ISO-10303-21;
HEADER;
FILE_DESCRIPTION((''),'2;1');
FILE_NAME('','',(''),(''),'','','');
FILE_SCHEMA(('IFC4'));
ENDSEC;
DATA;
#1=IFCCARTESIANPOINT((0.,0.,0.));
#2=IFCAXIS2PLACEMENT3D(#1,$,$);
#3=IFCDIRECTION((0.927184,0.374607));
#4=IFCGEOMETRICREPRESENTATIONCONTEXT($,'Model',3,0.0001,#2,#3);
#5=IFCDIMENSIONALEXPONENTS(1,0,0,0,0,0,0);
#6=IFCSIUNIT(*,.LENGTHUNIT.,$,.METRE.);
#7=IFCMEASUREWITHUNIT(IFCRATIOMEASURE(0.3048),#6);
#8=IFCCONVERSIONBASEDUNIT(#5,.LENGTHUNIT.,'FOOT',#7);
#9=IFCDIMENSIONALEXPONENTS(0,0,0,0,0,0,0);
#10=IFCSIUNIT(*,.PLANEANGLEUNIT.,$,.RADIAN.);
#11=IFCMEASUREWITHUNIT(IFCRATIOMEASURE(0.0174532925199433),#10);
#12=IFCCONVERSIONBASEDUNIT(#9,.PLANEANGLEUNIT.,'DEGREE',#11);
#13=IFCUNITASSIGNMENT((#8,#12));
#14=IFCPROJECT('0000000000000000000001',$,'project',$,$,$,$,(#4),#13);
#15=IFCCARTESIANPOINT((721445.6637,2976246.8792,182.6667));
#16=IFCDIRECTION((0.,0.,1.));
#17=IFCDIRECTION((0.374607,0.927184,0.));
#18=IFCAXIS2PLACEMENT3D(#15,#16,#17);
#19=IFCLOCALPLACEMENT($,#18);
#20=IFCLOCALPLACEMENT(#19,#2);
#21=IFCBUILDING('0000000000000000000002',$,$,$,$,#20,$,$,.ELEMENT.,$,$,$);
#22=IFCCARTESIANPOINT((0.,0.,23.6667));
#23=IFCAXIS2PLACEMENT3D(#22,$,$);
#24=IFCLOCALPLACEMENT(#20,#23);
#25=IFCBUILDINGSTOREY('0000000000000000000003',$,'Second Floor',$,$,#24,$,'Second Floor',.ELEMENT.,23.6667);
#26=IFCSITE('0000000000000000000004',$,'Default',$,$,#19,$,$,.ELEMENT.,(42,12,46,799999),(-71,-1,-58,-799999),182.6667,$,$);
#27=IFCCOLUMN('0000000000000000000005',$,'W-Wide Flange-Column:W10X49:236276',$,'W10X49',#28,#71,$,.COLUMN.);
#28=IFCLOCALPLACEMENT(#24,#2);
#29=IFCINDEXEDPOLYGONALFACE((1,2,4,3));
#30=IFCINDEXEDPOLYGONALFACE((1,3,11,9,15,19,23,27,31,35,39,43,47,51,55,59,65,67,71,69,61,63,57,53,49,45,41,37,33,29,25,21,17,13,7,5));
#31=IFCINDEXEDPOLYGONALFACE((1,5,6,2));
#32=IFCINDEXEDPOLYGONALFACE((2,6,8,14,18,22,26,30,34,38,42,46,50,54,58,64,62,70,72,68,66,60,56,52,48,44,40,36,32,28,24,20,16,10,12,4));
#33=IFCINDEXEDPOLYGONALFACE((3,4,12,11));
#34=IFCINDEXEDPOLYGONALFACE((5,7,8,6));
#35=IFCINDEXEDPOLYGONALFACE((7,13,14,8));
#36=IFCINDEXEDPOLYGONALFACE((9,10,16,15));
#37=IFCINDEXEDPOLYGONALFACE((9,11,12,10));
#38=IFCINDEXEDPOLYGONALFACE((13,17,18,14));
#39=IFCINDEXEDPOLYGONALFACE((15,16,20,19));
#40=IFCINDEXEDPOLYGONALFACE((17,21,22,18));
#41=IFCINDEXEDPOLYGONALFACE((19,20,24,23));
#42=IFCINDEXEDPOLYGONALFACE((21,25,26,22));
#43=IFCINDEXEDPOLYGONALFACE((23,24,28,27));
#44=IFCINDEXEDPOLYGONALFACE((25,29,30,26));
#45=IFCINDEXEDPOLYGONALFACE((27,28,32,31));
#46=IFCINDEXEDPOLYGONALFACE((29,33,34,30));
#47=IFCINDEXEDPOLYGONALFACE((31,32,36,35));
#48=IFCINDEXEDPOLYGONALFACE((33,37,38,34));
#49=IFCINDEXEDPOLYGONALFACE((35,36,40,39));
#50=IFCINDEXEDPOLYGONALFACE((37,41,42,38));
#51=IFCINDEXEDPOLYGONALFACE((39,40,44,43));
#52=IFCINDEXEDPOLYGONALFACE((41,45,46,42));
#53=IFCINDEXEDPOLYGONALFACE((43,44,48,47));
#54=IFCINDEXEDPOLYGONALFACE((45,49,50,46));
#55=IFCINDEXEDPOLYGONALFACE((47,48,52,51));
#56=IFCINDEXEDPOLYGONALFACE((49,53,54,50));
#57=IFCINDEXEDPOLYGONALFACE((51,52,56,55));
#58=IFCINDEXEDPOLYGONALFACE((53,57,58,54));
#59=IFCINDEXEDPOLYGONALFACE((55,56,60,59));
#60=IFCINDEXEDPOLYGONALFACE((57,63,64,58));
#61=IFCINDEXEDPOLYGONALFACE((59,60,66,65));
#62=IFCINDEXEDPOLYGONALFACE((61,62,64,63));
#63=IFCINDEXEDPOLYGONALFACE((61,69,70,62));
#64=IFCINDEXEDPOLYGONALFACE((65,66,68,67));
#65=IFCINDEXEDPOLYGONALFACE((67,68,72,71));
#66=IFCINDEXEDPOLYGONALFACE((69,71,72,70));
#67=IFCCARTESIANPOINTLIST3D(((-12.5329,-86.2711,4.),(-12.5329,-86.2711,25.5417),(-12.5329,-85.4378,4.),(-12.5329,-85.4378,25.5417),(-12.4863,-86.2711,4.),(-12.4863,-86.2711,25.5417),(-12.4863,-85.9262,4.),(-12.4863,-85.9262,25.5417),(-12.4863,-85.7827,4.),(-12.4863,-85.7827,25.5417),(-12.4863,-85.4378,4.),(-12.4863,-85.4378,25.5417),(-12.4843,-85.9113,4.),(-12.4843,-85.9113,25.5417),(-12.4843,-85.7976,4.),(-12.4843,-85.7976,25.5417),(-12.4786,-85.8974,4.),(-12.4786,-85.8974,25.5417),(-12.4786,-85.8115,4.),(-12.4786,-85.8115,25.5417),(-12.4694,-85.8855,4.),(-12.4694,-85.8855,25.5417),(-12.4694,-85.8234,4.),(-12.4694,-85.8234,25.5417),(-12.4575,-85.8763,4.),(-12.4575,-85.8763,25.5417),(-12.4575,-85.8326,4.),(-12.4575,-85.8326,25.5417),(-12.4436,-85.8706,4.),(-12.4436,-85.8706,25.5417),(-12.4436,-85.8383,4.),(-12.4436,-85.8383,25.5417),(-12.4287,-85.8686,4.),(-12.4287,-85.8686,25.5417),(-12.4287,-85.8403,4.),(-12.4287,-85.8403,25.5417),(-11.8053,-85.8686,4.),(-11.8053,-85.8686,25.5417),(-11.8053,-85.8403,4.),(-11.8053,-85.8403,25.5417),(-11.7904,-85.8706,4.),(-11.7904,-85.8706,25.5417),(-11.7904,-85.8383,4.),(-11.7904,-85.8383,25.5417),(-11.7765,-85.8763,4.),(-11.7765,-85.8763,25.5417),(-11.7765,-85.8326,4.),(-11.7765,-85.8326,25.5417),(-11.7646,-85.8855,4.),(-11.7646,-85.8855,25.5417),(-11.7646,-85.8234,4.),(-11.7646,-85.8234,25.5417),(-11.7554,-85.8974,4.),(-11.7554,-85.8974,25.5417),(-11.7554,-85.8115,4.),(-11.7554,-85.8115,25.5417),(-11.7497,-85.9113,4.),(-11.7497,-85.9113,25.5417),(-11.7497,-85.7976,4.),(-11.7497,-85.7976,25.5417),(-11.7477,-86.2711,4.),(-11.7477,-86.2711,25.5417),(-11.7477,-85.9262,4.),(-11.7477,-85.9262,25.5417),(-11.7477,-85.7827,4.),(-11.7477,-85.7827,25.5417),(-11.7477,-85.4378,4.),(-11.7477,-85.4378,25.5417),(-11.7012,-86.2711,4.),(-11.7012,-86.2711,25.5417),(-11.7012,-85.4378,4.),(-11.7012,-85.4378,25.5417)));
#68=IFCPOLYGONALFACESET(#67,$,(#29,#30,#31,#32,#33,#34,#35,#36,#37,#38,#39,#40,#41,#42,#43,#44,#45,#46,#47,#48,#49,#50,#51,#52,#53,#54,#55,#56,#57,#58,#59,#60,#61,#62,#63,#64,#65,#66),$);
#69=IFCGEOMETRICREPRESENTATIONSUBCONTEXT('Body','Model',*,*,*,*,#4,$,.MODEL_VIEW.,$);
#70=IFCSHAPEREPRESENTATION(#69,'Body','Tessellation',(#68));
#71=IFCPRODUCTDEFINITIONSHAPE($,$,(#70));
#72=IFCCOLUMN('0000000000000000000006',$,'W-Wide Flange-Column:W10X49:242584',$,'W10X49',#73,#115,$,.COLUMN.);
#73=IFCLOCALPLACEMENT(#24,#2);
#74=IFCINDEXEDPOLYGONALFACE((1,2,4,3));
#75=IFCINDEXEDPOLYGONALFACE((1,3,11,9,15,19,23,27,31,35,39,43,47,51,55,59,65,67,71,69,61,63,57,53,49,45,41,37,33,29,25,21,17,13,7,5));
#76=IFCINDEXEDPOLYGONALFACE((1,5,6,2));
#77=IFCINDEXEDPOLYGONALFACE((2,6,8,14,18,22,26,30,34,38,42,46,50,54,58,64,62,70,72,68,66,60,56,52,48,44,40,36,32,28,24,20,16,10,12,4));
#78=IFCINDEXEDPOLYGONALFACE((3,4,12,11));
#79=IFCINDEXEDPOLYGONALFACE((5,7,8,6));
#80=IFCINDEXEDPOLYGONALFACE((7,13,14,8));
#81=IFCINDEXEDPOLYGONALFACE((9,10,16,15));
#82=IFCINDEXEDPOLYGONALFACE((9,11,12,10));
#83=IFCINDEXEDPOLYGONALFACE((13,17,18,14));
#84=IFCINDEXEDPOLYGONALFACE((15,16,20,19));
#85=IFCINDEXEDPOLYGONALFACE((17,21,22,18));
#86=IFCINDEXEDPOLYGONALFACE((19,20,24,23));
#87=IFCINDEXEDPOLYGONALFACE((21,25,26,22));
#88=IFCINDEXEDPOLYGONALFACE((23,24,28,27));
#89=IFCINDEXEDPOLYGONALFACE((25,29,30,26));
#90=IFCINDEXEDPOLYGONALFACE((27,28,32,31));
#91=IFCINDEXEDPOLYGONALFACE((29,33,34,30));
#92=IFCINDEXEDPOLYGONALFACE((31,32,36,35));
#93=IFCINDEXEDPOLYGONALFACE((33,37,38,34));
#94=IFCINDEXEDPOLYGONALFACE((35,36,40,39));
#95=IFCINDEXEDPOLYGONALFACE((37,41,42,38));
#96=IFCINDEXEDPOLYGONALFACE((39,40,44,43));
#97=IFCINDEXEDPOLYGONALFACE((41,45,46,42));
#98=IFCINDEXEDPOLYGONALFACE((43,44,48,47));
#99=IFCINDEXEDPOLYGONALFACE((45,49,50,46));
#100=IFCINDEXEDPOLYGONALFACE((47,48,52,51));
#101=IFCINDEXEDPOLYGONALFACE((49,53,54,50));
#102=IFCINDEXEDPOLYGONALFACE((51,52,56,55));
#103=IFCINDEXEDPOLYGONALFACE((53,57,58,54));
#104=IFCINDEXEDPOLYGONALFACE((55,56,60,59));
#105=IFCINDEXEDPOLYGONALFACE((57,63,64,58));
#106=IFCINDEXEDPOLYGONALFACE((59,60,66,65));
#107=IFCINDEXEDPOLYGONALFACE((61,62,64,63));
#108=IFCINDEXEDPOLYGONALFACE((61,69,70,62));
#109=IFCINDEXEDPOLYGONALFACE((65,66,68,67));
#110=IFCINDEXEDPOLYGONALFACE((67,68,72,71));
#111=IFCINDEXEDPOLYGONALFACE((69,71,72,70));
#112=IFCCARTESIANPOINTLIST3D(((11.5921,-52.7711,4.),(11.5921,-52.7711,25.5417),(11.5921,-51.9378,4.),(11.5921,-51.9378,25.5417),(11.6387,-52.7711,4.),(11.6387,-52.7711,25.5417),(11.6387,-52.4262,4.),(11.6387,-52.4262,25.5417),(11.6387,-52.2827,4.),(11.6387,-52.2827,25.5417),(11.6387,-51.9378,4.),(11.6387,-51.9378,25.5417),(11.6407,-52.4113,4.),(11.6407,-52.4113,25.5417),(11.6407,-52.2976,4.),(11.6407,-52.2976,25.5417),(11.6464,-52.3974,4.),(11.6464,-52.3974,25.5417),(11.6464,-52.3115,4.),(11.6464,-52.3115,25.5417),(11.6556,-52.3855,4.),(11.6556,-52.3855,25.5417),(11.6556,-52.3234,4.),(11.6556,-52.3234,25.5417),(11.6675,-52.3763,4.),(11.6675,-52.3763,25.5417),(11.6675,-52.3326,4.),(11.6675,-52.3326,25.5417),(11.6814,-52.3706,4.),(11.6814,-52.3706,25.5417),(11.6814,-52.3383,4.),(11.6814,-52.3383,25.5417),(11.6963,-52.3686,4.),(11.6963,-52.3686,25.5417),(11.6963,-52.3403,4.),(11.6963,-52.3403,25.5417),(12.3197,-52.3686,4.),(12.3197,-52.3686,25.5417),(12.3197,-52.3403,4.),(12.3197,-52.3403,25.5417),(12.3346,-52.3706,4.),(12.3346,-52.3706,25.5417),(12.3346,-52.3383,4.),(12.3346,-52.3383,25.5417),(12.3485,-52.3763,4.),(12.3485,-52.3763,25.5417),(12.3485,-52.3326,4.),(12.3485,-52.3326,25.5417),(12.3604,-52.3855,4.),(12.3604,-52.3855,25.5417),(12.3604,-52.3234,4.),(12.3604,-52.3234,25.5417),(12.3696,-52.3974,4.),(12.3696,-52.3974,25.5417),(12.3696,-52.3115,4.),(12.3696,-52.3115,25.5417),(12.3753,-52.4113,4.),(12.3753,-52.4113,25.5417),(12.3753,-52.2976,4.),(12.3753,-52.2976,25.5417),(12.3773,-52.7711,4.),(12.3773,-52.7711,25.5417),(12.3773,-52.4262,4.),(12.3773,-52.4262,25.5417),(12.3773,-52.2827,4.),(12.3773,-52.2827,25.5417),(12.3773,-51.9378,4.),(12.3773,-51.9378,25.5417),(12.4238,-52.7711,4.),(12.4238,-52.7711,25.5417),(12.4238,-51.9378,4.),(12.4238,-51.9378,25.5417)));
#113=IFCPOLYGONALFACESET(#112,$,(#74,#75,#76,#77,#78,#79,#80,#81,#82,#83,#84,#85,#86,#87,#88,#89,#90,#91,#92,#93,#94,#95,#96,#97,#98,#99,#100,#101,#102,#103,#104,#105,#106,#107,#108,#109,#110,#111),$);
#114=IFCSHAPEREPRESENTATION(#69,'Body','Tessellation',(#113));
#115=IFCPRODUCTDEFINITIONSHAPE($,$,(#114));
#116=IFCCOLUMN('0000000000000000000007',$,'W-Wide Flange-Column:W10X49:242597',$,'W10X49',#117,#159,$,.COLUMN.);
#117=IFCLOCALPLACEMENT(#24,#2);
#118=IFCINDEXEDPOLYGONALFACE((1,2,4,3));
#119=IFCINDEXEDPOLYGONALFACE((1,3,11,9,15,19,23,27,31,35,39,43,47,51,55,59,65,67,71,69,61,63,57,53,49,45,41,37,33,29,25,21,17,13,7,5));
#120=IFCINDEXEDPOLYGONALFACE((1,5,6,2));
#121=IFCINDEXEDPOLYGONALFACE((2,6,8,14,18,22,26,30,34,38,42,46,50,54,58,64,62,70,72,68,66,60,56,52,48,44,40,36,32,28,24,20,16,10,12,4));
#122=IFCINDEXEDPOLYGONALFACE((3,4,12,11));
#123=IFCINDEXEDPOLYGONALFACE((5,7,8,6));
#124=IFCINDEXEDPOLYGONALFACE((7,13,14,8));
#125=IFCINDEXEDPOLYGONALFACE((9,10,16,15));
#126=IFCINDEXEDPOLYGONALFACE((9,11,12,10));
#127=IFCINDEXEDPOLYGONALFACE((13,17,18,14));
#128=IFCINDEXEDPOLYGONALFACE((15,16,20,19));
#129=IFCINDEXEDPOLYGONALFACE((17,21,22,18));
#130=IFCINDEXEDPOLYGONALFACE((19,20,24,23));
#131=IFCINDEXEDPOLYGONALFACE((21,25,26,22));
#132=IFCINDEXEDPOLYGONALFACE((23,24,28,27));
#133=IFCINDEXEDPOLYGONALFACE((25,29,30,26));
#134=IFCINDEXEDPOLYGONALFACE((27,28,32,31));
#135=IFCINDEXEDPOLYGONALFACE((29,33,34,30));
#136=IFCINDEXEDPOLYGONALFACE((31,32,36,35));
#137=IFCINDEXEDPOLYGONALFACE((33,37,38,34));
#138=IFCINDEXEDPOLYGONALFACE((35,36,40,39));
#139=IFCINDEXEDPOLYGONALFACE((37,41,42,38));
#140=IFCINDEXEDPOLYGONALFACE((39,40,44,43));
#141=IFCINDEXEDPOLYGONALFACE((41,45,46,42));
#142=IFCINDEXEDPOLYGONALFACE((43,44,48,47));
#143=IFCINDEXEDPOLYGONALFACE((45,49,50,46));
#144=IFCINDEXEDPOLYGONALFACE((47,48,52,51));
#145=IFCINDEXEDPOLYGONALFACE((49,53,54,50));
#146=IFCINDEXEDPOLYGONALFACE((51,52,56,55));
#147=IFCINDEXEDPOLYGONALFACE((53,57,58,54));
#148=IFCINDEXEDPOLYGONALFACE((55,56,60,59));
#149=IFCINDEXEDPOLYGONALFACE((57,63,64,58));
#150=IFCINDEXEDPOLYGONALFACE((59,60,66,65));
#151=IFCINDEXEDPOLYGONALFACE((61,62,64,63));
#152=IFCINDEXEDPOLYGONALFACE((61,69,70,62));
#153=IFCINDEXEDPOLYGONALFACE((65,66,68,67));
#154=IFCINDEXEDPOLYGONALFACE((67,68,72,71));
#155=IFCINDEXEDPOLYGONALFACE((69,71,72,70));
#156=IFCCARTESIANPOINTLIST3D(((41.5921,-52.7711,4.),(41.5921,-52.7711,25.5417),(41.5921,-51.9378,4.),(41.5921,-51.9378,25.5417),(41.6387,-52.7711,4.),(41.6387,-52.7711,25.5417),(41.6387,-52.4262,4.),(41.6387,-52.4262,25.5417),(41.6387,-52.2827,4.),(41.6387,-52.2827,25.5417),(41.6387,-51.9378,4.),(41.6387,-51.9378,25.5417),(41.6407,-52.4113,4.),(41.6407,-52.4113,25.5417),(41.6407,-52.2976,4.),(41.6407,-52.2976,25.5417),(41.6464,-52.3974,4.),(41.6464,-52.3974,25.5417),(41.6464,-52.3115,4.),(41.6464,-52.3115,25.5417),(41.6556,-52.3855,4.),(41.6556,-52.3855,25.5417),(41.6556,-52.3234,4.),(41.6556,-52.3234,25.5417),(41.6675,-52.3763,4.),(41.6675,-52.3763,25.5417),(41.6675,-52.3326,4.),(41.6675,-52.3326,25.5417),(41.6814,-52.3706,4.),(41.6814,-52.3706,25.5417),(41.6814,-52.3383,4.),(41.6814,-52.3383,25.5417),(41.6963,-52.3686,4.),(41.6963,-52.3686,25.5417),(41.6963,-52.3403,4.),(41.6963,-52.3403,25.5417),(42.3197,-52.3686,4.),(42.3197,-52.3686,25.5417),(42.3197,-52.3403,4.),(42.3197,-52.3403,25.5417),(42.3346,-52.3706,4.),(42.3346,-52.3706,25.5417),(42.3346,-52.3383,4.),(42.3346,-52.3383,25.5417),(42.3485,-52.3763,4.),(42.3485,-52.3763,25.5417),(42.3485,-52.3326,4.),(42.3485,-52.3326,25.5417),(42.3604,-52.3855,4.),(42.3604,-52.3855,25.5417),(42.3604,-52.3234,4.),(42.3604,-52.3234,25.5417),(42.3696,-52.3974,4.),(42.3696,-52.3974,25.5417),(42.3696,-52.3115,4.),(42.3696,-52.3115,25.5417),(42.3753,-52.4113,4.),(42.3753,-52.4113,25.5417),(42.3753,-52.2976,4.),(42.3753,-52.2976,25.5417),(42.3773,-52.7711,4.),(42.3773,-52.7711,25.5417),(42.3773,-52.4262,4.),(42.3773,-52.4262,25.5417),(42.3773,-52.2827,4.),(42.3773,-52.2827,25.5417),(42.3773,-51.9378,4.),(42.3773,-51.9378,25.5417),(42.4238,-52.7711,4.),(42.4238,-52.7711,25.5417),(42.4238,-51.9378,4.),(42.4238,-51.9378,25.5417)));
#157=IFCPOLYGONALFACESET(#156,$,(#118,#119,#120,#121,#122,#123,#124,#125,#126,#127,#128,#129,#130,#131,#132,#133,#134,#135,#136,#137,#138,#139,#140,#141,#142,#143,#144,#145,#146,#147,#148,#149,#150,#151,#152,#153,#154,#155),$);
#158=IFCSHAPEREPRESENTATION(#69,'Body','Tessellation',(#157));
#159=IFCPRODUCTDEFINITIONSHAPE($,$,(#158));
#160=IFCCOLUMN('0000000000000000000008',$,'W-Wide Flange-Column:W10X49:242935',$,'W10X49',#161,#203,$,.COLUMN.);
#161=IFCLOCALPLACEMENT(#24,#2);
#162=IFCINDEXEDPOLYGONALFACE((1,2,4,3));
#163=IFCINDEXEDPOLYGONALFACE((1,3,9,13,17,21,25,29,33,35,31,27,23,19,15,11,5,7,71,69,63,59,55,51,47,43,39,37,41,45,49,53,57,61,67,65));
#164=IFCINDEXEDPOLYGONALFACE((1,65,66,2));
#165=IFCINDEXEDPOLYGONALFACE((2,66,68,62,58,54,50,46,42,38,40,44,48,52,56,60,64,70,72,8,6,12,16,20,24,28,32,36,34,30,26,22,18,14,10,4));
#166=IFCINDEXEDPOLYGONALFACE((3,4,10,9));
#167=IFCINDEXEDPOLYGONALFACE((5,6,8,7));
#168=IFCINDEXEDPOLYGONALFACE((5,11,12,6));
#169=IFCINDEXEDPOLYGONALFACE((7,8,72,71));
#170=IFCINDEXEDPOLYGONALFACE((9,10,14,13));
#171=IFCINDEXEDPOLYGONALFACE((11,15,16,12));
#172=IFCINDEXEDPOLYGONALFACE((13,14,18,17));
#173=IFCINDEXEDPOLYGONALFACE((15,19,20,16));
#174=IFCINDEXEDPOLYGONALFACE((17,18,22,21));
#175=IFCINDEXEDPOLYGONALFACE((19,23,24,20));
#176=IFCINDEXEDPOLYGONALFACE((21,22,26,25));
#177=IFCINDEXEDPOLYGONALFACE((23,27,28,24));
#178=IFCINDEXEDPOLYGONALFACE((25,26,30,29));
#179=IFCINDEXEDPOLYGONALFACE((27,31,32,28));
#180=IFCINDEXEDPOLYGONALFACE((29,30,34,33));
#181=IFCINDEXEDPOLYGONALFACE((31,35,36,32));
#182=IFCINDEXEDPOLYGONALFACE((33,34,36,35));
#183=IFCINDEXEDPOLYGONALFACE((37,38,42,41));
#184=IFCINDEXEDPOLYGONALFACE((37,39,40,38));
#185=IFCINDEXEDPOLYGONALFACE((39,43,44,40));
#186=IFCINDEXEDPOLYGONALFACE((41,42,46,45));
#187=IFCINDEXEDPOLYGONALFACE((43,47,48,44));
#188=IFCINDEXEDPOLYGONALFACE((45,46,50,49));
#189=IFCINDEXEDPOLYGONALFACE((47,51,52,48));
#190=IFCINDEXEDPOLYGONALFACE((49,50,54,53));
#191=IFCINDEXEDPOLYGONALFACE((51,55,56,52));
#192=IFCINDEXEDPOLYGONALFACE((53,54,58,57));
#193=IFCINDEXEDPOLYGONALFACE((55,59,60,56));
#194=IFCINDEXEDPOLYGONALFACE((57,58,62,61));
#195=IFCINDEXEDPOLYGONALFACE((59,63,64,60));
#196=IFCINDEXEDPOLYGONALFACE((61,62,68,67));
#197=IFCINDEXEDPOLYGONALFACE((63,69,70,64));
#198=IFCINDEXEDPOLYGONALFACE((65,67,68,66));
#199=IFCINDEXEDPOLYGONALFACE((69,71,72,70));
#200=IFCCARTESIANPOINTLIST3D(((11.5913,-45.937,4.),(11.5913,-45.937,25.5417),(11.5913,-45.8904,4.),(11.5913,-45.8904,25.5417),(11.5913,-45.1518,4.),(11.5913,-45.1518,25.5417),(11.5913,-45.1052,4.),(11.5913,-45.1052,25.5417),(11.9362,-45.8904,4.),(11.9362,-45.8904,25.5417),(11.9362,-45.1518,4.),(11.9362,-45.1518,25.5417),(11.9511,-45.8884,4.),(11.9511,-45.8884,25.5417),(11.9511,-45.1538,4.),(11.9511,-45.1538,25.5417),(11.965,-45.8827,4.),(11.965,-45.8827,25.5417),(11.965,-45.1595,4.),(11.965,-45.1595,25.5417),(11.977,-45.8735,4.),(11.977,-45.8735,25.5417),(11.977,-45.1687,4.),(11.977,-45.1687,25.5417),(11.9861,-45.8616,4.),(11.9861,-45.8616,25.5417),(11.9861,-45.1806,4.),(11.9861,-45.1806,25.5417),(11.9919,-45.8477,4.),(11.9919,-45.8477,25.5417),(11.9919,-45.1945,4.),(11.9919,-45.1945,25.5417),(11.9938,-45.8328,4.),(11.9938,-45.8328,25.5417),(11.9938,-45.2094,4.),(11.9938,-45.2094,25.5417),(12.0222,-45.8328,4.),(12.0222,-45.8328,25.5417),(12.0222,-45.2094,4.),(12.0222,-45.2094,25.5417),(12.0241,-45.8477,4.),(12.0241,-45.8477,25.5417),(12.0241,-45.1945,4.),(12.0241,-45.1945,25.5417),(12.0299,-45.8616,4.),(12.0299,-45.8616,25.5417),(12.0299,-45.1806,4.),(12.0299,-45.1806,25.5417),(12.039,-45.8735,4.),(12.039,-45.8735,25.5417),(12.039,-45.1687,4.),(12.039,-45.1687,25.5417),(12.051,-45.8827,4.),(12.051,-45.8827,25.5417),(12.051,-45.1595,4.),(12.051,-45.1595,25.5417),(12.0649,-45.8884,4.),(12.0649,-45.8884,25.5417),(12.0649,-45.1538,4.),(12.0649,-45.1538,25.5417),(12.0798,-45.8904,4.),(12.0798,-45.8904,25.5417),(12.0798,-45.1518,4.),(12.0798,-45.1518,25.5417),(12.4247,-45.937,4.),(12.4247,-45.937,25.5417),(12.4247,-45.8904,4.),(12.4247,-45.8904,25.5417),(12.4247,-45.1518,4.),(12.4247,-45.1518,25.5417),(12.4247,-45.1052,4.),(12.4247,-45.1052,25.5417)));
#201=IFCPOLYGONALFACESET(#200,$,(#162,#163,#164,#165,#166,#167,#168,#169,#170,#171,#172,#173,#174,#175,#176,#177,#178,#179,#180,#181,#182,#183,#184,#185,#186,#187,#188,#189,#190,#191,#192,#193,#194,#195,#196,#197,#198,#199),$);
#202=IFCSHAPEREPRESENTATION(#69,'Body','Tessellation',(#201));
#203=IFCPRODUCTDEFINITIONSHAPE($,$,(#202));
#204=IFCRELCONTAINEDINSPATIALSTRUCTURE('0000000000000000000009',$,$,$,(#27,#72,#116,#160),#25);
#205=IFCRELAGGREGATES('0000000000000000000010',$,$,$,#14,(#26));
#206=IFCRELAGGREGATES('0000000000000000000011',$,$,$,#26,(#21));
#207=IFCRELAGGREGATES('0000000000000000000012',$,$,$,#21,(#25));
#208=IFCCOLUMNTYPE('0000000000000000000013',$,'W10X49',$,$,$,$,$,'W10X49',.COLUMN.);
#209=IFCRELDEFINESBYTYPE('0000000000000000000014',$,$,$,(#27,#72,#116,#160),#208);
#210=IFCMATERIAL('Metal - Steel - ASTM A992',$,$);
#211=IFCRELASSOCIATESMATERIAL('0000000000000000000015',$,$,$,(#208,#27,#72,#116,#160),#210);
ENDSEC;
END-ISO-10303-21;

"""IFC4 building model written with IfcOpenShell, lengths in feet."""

from ifc_helpers import new_model, entity, si_unit, converted_unit, direction, frame, frame_2d, origin, place, context, subcontext, project, spatial, i_section, extrude, source, transform, mapped, material, type_object, type_shapes, element, save


model = new_model("IFC4")

# Units and contexts
model_context = context("Model", 3, precision=0.0001, world=origin(), true_north=direction((0.927184, 0.374607)))
body_context = subcontext(model_context, "Body", "Model", "MODEL_VIEW")
ifc_project = project(units=[converted_unit("LENGTHUNIT", "FOOT", entity("IfcRatioMeasure", 0.3048), si_unit("LENGTHUNIT", "METRE"), dimensions=[1, 0, 0, 0, 0, 0, 0]), converted_unit("PLANEANGLEUNIT", "DEGREE", entity("IfcRatioMeasure", 0.0174532925199433), si_unit("PLANEANGLEUNIT", "RADIAN"), dimensions=[0, 0, 0, 0, 0, 0, 0])], contexts=[model_context])

# Site, building, storey
site_placement = place(None, frame((721445.6637, 2976246.8792, 182.6667), z_axis=(0.0, 0.0, 1.0), x_axis=(0.374607, 0.927184, 0.0)))
site = spatial("IfcSite", under=ifc_project, at=site_placement, Name="Default", CompositionType="ELEMENT", RefLatitude=(42, 12, 46, 799999), RefLongitude=(-71, -1, -58, -799999), RefElevation=182.6667)
building_placement = place(site_placement, origin())
building = spatial("IfcBuilding", under=site, at=building_placement, CompositionType="ELEMENT")
storey_placement = place(building_placement, frame((0.0, 0.0, 23.6667)))
storey = spatial("IfcBuildingStorey", under=building, at=storey_placement, Name="Second Floor", LongName="Second Floor", CompositionType="ELEMENT", Elevation=23.6667)

# Columns
ifc_material_1 = material(Name="Metal - Steel - ASTM A992")
column_type = type_object("IfcColumnType", Name="W10X49", ElementType="W10X49", PredefinedType="COLUMN", material=ifc_material_1)
shared_shape_1 = source(origin(), body_context, "Body", "SweptSolid", [
    extrude(i_section(OverallWidth=0.8333, OverallDepth=0.8317, WebThickness=0.0283, FlangeThickness=0.0465, FilletRadius=0.0576, at=frame_2d((0.0, 0.0), x_axis=(0.0, 1.0))), frame((0.0, 0.0, 27.6667), z_axis=(0.0, 0.0, 1.0), x_axis=(0.0, -1.0, 0.0)), (0.0, 0.0, 1.0), 21.5417),
])
type_shapes(column_type, [shared_shape_1])
for number, where, z_axis, x_axis, name in (
    (1, (-12.117, -85.8544, -23.6667), (0.0, 0.0, 1.0), (0.0, 1.0, 0.0), "W-Wide Flange-Column:W10X49:236276"),
    (2, (12.008, -52.3544, -23.6667), (0.0, 0.0, 1.0), (0.0, 1.0, 0.0), "W-Wide Flange-Column:W10X49:242584"),
    (3, (42.008, -52.3544, -23.6667), (0.0, 0.0, 1.0), (0.0, 1.0, 0.0), "W-Wide Flange-Column:W10X49:242597"),
    (4, (12.008, -45.5211, -23.6667), (0.0, 0.0, 1.0), (-1.0, 0.0, 0.0), "W-Wide Flange-Column:W10X49:242935"),
):
    element("IfcColumn", number, at=place(storey_placement, frame(where, z_axis=z_axis, x_axis=x_axis)), inside=storey, type_object=column_type, material=ifc_material_1, Name=name, ObjectType="W10X49", PredefinedType="COLUMN", context=body_context, shape_type="MappedRepresentation", body=[
        mapped(shared_shape_1, transform((0.0, 0.0, 0.0), scale=1.0)),
    ])

save(model, "model.ifc")
